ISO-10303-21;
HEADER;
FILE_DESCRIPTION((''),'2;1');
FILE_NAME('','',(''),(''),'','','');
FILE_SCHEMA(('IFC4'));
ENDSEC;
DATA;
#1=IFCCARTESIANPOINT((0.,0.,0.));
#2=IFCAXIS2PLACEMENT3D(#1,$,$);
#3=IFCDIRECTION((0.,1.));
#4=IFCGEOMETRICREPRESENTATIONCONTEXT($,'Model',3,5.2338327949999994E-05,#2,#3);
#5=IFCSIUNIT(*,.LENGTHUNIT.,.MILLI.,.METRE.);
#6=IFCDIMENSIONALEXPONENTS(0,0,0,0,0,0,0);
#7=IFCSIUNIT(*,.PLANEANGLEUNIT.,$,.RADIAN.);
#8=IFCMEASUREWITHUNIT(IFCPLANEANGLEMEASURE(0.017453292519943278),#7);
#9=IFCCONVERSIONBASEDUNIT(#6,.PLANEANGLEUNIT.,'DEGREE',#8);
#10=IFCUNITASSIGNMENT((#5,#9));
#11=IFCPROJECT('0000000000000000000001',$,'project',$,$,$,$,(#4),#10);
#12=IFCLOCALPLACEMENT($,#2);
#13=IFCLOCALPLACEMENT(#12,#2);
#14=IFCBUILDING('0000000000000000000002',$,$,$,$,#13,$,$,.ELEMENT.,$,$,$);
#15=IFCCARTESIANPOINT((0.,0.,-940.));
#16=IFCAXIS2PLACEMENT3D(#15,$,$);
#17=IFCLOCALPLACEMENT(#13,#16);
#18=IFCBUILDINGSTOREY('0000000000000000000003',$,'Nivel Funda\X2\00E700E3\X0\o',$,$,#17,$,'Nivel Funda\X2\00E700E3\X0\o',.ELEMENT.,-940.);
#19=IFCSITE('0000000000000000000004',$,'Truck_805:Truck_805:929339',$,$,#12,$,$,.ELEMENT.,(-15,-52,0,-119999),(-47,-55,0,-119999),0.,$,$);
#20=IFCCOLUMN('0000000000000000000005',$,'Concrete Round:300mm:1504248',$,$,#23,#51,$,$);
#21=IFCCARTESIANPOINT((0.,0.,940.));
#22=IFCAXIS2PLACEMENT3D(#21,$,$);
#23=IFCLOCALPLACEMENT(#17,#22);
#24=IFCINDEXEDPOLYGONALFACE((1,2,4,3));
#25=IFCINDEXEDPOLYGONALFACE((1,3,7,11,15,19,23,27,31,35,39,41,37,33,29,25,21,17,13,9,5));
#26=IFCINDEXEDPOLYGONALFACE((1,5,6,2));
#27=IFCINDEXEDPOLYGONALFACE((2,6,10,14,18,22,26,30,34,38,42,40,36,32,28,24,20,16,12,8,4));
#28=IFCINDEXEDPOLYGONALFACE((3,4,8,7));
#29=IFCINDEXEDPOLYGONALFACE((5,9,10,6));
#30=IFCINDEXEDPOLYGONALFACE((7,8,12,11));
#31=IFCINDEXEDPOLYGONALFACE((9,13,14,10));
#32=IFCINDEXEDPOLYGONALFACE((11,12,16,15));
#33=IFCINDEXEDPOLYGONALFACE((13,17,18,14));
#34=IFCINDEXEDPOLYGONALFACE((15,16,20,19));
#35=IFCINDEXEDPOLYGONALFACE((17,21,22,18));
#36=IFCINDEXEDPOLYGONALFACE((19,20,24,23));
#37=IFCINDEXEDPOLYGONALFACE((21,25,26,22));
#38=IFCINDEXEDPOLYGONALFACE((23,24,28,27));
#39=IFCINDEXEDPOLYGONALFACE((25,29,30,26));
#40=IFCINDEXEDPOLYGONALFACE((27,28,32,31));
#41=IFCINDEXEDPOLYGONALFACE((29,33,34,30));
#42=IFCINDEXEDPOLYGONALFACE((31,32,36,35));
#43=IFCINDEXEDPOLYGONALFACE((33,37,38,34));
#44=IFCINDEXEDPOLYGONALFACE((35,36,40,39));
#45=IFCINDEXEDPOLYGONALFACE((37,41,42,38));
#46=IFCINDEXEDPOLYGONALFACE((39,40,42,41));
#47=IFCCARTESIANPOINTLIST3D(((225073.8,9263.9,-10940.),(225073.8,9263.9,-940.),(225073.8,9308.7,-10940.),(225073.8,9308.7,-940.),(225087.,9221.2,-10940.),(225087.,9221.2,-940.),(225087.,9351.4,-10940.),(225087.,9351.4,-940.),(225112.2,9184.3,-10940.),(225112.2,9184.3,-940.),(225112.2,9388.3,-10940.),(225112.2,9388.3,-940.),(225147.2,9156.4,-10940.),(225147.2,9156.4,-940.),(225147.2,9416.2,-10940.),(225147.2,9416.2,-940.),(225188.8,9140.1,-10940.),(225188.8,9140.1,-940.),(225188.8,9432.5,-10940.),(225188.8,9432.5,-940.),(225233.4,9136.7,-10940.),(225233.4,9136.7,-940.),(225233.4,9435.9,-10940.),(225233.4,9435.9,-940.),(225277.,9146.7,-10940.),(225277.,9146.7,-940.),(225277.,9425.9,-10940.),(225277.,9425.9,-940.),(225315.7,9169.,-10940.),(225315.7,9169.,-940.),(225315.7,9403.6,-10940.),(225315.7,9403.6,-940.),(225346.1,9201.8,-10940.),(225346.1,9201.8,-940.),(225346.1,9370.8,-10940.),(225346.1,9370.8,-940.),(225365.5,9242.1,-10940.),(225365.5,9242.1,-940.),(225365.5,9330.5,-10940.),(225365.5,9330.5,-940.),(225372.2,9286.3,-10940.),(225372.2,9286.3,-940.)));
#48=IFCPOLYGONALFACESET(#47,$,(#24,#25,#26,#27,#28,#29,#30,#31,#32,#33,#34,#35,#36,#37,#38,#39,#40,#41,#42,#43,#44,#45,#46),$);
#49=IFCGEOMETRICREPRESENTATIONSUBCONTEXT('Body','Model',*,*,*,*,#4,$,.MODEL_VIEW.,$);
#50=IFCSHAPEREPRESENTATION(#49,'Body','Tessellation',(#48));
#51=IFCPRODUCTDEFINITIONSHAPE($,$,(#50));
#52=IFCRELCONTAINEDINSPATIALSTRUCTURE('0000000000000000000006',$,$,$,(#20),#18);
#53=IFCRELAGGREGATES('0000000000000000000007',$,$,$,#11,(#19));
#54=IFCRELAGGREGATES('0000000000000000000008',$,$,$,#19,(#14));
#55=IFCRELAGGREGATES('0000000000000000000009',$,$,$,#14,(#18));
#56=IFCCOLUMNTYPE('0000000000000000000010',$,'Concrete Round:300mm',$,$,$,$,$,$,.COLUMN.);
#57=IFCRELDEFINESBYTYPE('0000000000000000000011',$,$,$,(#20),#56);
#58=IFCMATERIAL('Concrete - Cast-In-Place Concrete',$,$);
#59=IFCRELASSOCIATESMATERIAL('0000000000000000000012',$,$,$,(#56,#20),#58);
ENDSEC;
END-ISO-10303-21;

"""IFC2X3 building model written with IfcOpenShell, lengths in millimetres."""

from ifc_helpers import new_model, entity, si_unit, converted_unit, direction, frame, origin, origin_2d_with_axis, place, context, subcontext, project, spatial, circle, extrude, source, transform, mapped, material, type_object, type_shapes, element, save


model = new_model("IFC2X3")

# Units and contexts
model_context = context("Model", 3, precision=5.2338327949999994e-05, world=origin(), true_north=direction((0.0, 1.0)))
body_context = subcontext(model_context, "Body", "Model", "MODEL_VIEW")
ifc_project = project(units=[si_unit("LENGTHUNIT", "METRE", prefix="MILLI"), converted_unit("PLANEANGLEUNIT", "DEGREE", entity("IfcPlaneAngleMeasure", 0.017453292519943278), si_unit("PLANEANGLEUNIT", "RADIAN"), dimensions=[0, 0, 0, 0, 0, 0, 0])], contexts=[model_context])

# Site, building, storey
site_placement = place(None, origin())
site = spatial("IfcSite", under=ifc_project, at=site_placement, Name="Truck_805:Truck_805:929339", CompositionType="ELEMENT", RefLatitude=(-15, -52, 0, -119999), RefLongitude=(-47, -55, 0, -119999), RefElevation=0.0)
building_placement = place(site_placement, origin())
building = spatial("IfcBuilding", under=site, at=building_placement, CompositionType="ELEMENT")
storey_placement = place(building_placement, frame((0.0, 0.0, -940.0)))
storey = spatial("IfcBuildingStorey", under=building, at=storey_placement, Name="Nivel Fundação", LongName="Nivel Fundação", CompositionType="ELEMENT", Elevation=-940.0)

# Column
ifc_material = material(Name="Concrete - Cast-In-Place Concrete")
column_type_1 = type_object("IfcColumnType", Name="Concrete Round:300mm", PredefinedType="COLUMN", material=ifc_material)
shared_shape_1 = source(origin(), body_context, "Body", "SweptSolid", [
    extrude(circle(Radius=150.0, at=origin_2d_with_axis()), frame((225222.2, 9286.3, -10940.0)), (0.0, 0.0, 1.0), 10000.0),
])
type_shapes(column_type_1, [shared_shape_1])
column_1_placement = place(storey_placement, frame((0.0, 0.0, 940.0)))
element("IfcColumn", 1, at=column_1_placement, inside=storey, type_object=column_type_1, material=ifc_material, Name="Concrete Round:300mm:1504248", context=body_context, shape_type="MappedRepresentation", body=[
    mapped(shared_shape_1, transform((0.0, 0.0, 0.0), scale=1.0)),
])

save(model, "model.ifc")
